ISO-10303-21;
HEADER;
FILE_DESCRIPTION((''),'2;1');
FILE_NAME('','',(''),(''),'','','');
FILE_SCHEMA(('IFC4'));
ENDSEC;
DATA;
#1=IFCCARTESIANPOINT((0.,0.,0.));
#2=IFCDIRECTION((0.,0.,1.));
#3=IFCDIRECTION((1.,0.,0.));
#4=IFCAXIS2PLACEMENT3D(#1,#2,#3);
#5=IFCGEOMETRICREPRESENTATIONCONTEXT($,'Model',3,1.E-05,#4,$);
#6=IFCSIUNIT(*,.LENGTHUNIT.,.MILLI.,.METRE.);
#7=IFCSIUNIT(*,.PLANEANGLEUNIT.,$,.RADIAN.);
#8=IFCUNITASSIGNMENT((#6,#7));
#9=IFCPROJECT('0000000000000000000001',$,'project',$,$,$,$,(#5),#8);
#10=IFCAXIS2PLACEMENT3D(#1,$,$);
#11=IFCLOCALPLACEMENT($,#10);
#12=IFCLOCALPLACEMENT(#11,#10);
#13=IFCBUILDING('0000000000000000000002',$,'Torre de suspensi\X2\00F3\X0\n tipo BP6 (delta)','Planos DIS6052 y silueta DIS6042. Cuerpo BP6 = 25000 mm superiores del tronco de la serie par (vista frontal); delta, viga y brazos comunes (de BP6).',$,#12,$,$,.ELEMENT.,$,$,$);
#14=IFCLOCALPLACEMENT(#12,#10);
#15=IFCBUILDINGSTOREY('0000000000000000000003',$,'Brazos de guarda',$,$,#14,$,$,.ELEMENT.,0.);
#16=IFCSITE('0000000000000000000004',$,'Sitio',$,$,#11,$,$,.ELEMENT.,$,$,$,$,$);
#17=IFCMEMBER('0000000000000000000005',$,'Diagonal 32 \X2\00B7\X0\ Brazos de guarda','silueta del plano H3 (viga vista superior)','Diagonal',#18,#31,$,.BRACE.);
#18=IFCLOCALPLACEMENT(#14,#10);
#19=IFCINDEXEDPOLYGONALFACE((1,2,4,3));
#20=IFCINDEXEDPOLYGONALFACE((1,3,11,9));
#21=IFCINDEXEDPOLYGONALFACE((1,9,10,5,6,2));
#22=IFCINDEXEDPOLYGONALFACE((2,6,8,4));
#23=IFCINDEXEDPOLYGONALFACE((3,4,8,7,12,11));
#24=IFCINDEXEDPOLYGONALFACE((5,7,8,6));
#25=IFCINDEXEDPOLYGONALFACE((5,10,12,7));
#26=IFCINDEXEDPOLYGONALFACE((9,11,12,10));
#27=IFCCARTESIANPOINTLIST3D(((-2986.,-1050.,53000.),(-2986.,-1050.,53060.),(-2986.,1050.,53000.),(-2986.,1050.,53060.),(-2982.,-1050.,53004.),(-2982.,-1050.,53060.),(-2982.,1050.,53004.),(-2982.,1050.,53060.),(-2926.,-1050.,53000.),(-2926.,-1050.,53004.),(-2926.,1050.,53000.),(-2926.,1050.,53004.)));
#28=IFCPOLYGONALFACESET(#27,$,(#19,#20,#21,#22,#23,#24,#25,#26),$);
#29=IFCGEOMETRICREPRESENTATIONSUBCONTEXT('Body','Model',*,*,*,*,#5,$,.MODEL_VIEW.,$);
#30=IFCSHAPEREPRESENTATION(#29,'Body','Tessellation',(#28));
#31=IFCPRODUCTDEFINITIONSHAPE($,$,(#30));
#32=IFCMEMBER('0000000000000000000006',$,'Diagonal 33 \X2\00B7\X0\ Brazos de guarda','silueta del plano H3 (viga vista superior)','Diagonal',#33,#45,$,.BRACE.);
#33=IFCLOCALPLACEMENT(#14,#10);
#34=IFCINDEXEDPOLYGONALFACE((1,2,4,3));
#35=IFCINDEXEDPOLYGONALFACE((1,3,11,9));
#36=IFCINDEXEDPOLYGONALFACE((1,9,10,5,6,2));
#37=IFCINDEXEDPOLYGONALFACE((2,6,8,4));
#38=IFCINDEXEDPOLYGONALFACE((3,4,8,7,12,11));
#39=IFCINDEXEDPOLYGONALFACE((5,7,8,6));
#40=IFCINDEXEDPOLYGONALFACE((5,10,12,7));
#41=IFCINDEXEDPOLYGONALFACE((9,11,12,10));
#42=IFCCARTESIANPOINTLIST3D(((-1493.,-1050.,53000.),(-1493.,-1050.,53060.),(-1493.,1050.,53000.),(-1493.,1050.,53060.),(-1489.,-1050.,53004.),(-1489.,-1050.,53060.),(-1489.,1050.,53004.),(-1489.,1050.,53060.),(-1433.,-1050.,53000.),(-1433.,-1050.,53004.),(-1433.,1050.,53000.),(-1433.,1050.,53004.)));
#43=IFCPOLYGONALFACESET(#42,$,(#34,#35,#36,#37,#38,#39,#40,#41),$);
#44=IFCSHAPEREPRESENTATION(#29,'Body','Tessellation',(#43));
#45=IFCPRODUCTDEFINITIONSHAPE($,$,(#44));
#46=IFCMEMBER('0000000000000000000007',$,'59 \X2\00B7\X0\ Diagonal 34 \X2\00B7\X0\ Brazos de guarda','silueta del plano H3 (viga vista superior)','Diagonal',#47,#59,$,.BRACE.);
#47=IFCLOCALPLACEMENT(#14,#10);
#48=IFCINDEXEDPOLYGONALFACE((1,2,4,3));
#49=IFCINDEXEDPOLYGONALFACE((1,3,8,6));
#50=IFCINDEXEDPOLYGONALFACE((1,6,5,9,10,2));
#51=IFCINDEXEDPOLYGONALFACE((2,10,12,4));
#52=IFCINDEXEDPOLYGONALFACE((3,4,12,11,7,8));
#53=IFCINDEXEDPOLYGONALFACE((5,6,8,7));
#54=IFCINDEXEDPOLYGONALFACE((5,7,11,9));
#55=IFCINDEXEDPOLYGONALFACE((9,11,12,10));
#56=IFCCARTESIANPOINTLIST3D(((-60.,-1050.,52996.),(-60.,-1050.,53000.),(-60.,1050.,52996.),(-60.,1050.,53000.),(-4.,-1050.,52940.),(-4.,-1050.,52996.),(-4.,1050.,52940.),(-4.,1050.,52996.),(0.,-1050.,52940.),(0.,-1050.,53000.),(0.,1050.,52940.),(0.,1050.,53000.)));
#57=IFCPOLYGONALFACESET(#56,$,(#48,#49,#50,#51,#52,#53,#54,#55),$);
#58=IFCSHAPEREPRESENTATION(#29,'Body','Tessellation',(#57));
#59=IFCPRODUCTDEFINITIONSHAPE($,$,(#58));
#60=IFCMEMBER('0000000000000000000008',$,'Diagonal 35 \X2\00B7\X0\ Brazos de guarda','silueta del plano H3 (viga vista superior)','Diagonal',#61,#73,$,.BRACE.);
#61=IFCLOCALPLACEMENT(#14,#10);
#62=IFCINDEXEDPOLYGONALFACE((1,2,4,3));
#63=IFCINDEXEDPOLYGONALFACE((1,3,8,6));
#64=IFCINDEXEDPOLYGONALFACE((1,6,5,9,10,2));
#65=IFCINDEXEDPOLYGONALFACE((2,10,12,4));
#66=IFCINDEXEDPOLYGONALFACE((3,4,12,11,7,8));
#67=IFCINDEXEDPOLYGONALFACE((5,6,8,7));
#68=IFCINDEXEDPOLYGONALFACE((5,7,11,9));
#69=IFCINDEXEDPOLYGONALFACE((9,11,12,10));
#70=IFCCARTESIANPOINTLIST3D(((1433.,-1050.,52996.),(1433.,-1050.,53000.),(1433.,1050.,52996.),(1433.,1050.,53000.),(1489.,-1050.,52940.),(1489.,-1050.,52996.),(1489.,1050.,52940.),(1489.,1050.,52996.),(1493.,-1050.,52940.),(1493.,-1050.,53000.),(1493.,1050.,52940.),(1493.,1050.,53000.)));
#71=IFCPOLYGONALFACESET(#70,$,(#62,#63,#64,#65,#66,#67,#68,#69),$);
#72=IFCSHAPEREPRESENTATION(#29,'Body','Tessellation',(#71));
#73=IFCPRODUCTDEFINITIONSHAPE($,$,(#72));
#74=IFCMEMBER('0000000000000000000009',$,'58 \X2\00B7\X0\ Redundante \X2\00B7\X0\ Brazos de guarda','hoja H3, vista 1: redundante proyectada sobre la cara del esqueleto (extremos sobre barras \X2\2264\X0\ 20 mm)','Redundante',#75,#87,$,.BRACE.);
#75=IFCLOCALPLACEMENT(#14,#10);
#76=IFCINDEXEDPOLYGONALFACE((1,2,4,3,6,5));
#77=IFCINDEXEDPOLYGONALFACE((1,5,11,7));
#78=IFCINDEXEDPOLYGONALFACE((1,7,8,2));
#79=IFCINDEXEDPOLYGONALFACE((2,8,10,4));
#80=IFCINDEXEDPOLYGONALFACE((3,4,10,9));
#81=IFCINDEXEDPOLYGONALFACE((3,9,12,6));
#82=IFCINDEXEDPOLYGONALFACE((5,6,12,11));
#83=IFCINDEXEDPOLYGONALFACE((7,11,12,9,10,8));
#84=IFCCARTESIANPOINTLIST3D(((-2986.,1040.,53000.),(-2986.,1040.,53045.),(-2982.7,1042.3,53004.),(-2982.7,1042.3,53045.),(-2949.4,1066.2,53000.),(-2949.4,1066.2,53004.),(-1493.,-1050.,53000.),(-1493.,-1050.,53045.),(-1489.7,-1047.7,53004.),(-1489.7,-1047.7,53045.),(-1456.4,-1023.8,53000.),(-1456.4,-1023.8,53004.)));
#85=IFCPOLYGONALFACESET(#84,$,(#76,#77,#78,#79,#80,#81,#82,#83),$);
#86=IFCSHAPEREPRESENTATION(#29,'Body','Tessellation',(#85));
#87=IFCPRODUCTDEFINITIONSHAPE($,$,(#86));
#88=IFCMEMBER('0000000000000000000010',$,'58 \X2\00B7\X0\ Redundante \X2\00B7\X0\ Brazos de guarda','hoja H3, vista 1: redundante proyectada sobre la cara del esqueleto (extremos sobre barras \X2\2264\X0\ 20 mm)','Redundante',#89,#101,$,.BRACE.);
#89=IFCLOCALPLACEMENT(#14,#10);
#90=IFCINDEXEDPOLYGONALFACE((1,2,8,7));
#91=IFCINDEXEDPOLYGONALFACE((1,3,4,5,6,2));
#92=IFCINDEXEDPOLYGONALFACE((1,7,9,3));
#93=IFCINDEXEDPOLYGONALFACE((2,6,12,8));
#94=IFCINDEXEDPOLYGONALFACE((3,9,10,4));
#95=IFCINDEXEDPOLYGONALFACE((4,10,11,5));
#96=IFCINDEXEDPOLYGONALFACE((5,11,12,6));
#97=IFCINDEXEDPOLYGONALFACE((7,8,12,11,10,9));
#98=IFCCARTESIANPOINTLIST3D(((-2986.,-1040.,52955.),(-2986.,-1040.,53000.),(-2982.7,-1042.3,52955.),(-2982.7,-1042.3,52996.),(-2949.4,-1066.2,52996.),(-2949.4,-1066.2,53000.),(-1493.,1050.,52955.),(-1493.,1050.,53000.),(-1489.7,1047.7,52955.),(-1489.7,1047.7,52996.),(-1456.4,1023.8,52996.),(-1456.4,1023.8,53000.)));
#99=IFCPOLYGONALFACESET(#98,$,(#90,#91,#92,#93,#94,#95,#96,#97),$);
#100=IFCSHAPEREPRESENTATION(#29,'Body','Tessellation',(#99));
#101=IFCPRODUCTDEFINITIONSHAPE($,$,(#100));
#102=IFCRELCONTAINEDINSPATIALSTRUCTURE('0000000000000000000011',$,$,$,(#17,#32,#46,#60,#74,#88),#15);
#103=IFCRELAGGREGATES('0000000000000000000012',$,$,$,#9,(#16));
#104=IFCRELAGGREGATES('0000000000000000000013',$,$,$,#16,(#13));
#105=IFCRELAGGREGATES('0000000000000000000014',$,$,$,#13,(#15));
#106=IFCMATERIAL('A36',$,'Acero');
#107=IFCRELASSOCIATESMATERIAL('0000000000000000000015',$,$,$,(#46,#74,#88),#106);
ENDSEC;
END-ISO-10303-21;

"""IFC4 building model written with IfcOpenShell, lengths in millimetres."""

from ifc_helpers import new_model, si_unit, frame, frame_2d, origin, origin_with_axes, place, context, subcontext, project, spatial, l_section, extrude, material, element, save


model = new_model("IFC4")

# Units and contexts
model_context = context("Model", 3, precision=1e-05, world=origin_with_axes())
body_context = subcontext(model_context, "Body", "Model", "MODEL_VIEW")
ifc_project = project(units=[si_unit("LENGTHUNIT", "METRE", prefix="MILLI"), si_unit("PLANEANGLEUNIT", "RADIAN")], contexts=[model_context])

# Site, building, storey
site_placement = place(None, origin())
site = spatial("IfcSite", under=ifc_project, at=site_placement, Name="Sitio", CompositionType="ELEMENT")
building_placement = place(site_placement, origin())
building = spatial("IfcBuilding", under=site, at=building_placement, Name="Torre de suspensión tipo BP6 (delta)", Description="Planos DIS6052 y silueta DIS6042. Cuerpo BP6 = 25000 mm superiores del tronco de la serie par (vista frontal); delta, viga y brazos comunes (de BP6).", CompositionType="ELEMENT")
storey_placement = place(building_placement, origin())
storey = spatial("IfcBuildingStorey", under=building, at=storey_placement, Name="Brazos de guarda", CompositionType="ELEMENT", Elevation=0.0)

# Members
for number, where, z_axis, x_axis, name in (
    (1, (-2986.0, 1050.0, 53000.0), (0.0, -1.0, 0.0), (1.0, 0.0, 0.0), "Diagonal 32 · Brazos de guarda"),
    (2, (-1493.0, 1050.0, 53000.0), (0.0, -1.0, 0.0), (1.0, 0.0, 0.0), "Diagonal 33 · Brazos de guarda"),
):
    element("IfcMember", number, at=place(storey_placement, frame(where, z_axis=z_axis, x_axis=x_axis)), inside=storey, Name=name, Description="silueta del plano H3 (viga vista superior)", ObjectType="Diagonal", PredefinedType="BRACE", context=body_context, shape_type="SweptSolid", body=[
        extrude(l_section(Depth=60.0, Width=60.0, Thickness=4.0, at=frame_2d((30.0, 30.0))), None, (0.0, 0.0, 1.0), 2100.0),
    ])
ifc_material_1 = material(Name="A36", Category="Acero")
member_1_placement = place(storey_placement, frame((0.0, 1050.0, 53000.0), z_axis=(0.0, -1.0, 0.0), x_axis=(-1.0, 0.0, 0.0)))
element("IfcMember", 3, at=member_1_placement, inside=storey, material=ifc_material_1, Name="59 · Diagonal 34 · Brazos de guarda", Description="silueta del plano H3 (viga vista superior)", ObjectType="Diagonal", PredefinedType="BRACE", context=body_context, shape_type="SweptSolid", body=[
    extrude(l_section(Depth=60.0, Width=60.0, Thickness=4.0, at=frame_2d((30.0, 30.0))), None, (0.0, 0.0, 1.0), 2100.0),
])
member_2_placement = place(storey_placement, frame((1493.0, 1050.0, 53000.0), z_axis=(0.0, -1.0, 0.0), x_axis=(-1.0, 0.0, 0.0)))
element("IfcMember", 4, at=member_2_placement, inside=storey, Name="Diagonal 35 · Brazos de guarda", Description="silueta del plano H3 (viga vista superior)", ObjectType="Diagonal", PredefinedType="BRACE", context=body_context, shape_type="SweptSolid", body=[
    extrude(l_section(Depth=60.0, Width=60.0, Thickness=4.0, at=frame_2d((30.0, 30.0))), None, (0.0, 0.0, 1.0), 2100.0),
])
for number, where, z_axis, x_axis, name in (
    (5, (-2986.0, 1040.0, 53000.0), (0.581275, -0.813707, 0.0), (0.813707, 0.581275, 0.0), "58 · Redundante · Brazos de guarda"),
    (6, (-2986.0, -1040.0, 53000.0), (0.581275, 0.813707, 0.0), (0.813707, -0.581275, 0.0), "58 · Redundante · Brazos de guarda"),
):
    element("IfcMember", number, at=place(storey_placement, frame(where, z_axis=z_axis, x_axis=x_axis)), inside=storey, material=ifc_material_1, Name=name, Description="hoja H3, vista 1: redundante proyectada sobre la cara del esqueleto (extremos sobre barras ≤ 20 mm)", ObjectType="Redundante", PredefinedType="BRACE", context=body_context, shape_type="SweptSolid", body=[
        extrude(l_section(Depth=45.0, Width=45.0, Thickness=4.0, at=frame_2d((22.5, 22.5))), None, (0.0, 0.0, 1.0), 2568.5),
    ])

save(model, "model.ifc")
